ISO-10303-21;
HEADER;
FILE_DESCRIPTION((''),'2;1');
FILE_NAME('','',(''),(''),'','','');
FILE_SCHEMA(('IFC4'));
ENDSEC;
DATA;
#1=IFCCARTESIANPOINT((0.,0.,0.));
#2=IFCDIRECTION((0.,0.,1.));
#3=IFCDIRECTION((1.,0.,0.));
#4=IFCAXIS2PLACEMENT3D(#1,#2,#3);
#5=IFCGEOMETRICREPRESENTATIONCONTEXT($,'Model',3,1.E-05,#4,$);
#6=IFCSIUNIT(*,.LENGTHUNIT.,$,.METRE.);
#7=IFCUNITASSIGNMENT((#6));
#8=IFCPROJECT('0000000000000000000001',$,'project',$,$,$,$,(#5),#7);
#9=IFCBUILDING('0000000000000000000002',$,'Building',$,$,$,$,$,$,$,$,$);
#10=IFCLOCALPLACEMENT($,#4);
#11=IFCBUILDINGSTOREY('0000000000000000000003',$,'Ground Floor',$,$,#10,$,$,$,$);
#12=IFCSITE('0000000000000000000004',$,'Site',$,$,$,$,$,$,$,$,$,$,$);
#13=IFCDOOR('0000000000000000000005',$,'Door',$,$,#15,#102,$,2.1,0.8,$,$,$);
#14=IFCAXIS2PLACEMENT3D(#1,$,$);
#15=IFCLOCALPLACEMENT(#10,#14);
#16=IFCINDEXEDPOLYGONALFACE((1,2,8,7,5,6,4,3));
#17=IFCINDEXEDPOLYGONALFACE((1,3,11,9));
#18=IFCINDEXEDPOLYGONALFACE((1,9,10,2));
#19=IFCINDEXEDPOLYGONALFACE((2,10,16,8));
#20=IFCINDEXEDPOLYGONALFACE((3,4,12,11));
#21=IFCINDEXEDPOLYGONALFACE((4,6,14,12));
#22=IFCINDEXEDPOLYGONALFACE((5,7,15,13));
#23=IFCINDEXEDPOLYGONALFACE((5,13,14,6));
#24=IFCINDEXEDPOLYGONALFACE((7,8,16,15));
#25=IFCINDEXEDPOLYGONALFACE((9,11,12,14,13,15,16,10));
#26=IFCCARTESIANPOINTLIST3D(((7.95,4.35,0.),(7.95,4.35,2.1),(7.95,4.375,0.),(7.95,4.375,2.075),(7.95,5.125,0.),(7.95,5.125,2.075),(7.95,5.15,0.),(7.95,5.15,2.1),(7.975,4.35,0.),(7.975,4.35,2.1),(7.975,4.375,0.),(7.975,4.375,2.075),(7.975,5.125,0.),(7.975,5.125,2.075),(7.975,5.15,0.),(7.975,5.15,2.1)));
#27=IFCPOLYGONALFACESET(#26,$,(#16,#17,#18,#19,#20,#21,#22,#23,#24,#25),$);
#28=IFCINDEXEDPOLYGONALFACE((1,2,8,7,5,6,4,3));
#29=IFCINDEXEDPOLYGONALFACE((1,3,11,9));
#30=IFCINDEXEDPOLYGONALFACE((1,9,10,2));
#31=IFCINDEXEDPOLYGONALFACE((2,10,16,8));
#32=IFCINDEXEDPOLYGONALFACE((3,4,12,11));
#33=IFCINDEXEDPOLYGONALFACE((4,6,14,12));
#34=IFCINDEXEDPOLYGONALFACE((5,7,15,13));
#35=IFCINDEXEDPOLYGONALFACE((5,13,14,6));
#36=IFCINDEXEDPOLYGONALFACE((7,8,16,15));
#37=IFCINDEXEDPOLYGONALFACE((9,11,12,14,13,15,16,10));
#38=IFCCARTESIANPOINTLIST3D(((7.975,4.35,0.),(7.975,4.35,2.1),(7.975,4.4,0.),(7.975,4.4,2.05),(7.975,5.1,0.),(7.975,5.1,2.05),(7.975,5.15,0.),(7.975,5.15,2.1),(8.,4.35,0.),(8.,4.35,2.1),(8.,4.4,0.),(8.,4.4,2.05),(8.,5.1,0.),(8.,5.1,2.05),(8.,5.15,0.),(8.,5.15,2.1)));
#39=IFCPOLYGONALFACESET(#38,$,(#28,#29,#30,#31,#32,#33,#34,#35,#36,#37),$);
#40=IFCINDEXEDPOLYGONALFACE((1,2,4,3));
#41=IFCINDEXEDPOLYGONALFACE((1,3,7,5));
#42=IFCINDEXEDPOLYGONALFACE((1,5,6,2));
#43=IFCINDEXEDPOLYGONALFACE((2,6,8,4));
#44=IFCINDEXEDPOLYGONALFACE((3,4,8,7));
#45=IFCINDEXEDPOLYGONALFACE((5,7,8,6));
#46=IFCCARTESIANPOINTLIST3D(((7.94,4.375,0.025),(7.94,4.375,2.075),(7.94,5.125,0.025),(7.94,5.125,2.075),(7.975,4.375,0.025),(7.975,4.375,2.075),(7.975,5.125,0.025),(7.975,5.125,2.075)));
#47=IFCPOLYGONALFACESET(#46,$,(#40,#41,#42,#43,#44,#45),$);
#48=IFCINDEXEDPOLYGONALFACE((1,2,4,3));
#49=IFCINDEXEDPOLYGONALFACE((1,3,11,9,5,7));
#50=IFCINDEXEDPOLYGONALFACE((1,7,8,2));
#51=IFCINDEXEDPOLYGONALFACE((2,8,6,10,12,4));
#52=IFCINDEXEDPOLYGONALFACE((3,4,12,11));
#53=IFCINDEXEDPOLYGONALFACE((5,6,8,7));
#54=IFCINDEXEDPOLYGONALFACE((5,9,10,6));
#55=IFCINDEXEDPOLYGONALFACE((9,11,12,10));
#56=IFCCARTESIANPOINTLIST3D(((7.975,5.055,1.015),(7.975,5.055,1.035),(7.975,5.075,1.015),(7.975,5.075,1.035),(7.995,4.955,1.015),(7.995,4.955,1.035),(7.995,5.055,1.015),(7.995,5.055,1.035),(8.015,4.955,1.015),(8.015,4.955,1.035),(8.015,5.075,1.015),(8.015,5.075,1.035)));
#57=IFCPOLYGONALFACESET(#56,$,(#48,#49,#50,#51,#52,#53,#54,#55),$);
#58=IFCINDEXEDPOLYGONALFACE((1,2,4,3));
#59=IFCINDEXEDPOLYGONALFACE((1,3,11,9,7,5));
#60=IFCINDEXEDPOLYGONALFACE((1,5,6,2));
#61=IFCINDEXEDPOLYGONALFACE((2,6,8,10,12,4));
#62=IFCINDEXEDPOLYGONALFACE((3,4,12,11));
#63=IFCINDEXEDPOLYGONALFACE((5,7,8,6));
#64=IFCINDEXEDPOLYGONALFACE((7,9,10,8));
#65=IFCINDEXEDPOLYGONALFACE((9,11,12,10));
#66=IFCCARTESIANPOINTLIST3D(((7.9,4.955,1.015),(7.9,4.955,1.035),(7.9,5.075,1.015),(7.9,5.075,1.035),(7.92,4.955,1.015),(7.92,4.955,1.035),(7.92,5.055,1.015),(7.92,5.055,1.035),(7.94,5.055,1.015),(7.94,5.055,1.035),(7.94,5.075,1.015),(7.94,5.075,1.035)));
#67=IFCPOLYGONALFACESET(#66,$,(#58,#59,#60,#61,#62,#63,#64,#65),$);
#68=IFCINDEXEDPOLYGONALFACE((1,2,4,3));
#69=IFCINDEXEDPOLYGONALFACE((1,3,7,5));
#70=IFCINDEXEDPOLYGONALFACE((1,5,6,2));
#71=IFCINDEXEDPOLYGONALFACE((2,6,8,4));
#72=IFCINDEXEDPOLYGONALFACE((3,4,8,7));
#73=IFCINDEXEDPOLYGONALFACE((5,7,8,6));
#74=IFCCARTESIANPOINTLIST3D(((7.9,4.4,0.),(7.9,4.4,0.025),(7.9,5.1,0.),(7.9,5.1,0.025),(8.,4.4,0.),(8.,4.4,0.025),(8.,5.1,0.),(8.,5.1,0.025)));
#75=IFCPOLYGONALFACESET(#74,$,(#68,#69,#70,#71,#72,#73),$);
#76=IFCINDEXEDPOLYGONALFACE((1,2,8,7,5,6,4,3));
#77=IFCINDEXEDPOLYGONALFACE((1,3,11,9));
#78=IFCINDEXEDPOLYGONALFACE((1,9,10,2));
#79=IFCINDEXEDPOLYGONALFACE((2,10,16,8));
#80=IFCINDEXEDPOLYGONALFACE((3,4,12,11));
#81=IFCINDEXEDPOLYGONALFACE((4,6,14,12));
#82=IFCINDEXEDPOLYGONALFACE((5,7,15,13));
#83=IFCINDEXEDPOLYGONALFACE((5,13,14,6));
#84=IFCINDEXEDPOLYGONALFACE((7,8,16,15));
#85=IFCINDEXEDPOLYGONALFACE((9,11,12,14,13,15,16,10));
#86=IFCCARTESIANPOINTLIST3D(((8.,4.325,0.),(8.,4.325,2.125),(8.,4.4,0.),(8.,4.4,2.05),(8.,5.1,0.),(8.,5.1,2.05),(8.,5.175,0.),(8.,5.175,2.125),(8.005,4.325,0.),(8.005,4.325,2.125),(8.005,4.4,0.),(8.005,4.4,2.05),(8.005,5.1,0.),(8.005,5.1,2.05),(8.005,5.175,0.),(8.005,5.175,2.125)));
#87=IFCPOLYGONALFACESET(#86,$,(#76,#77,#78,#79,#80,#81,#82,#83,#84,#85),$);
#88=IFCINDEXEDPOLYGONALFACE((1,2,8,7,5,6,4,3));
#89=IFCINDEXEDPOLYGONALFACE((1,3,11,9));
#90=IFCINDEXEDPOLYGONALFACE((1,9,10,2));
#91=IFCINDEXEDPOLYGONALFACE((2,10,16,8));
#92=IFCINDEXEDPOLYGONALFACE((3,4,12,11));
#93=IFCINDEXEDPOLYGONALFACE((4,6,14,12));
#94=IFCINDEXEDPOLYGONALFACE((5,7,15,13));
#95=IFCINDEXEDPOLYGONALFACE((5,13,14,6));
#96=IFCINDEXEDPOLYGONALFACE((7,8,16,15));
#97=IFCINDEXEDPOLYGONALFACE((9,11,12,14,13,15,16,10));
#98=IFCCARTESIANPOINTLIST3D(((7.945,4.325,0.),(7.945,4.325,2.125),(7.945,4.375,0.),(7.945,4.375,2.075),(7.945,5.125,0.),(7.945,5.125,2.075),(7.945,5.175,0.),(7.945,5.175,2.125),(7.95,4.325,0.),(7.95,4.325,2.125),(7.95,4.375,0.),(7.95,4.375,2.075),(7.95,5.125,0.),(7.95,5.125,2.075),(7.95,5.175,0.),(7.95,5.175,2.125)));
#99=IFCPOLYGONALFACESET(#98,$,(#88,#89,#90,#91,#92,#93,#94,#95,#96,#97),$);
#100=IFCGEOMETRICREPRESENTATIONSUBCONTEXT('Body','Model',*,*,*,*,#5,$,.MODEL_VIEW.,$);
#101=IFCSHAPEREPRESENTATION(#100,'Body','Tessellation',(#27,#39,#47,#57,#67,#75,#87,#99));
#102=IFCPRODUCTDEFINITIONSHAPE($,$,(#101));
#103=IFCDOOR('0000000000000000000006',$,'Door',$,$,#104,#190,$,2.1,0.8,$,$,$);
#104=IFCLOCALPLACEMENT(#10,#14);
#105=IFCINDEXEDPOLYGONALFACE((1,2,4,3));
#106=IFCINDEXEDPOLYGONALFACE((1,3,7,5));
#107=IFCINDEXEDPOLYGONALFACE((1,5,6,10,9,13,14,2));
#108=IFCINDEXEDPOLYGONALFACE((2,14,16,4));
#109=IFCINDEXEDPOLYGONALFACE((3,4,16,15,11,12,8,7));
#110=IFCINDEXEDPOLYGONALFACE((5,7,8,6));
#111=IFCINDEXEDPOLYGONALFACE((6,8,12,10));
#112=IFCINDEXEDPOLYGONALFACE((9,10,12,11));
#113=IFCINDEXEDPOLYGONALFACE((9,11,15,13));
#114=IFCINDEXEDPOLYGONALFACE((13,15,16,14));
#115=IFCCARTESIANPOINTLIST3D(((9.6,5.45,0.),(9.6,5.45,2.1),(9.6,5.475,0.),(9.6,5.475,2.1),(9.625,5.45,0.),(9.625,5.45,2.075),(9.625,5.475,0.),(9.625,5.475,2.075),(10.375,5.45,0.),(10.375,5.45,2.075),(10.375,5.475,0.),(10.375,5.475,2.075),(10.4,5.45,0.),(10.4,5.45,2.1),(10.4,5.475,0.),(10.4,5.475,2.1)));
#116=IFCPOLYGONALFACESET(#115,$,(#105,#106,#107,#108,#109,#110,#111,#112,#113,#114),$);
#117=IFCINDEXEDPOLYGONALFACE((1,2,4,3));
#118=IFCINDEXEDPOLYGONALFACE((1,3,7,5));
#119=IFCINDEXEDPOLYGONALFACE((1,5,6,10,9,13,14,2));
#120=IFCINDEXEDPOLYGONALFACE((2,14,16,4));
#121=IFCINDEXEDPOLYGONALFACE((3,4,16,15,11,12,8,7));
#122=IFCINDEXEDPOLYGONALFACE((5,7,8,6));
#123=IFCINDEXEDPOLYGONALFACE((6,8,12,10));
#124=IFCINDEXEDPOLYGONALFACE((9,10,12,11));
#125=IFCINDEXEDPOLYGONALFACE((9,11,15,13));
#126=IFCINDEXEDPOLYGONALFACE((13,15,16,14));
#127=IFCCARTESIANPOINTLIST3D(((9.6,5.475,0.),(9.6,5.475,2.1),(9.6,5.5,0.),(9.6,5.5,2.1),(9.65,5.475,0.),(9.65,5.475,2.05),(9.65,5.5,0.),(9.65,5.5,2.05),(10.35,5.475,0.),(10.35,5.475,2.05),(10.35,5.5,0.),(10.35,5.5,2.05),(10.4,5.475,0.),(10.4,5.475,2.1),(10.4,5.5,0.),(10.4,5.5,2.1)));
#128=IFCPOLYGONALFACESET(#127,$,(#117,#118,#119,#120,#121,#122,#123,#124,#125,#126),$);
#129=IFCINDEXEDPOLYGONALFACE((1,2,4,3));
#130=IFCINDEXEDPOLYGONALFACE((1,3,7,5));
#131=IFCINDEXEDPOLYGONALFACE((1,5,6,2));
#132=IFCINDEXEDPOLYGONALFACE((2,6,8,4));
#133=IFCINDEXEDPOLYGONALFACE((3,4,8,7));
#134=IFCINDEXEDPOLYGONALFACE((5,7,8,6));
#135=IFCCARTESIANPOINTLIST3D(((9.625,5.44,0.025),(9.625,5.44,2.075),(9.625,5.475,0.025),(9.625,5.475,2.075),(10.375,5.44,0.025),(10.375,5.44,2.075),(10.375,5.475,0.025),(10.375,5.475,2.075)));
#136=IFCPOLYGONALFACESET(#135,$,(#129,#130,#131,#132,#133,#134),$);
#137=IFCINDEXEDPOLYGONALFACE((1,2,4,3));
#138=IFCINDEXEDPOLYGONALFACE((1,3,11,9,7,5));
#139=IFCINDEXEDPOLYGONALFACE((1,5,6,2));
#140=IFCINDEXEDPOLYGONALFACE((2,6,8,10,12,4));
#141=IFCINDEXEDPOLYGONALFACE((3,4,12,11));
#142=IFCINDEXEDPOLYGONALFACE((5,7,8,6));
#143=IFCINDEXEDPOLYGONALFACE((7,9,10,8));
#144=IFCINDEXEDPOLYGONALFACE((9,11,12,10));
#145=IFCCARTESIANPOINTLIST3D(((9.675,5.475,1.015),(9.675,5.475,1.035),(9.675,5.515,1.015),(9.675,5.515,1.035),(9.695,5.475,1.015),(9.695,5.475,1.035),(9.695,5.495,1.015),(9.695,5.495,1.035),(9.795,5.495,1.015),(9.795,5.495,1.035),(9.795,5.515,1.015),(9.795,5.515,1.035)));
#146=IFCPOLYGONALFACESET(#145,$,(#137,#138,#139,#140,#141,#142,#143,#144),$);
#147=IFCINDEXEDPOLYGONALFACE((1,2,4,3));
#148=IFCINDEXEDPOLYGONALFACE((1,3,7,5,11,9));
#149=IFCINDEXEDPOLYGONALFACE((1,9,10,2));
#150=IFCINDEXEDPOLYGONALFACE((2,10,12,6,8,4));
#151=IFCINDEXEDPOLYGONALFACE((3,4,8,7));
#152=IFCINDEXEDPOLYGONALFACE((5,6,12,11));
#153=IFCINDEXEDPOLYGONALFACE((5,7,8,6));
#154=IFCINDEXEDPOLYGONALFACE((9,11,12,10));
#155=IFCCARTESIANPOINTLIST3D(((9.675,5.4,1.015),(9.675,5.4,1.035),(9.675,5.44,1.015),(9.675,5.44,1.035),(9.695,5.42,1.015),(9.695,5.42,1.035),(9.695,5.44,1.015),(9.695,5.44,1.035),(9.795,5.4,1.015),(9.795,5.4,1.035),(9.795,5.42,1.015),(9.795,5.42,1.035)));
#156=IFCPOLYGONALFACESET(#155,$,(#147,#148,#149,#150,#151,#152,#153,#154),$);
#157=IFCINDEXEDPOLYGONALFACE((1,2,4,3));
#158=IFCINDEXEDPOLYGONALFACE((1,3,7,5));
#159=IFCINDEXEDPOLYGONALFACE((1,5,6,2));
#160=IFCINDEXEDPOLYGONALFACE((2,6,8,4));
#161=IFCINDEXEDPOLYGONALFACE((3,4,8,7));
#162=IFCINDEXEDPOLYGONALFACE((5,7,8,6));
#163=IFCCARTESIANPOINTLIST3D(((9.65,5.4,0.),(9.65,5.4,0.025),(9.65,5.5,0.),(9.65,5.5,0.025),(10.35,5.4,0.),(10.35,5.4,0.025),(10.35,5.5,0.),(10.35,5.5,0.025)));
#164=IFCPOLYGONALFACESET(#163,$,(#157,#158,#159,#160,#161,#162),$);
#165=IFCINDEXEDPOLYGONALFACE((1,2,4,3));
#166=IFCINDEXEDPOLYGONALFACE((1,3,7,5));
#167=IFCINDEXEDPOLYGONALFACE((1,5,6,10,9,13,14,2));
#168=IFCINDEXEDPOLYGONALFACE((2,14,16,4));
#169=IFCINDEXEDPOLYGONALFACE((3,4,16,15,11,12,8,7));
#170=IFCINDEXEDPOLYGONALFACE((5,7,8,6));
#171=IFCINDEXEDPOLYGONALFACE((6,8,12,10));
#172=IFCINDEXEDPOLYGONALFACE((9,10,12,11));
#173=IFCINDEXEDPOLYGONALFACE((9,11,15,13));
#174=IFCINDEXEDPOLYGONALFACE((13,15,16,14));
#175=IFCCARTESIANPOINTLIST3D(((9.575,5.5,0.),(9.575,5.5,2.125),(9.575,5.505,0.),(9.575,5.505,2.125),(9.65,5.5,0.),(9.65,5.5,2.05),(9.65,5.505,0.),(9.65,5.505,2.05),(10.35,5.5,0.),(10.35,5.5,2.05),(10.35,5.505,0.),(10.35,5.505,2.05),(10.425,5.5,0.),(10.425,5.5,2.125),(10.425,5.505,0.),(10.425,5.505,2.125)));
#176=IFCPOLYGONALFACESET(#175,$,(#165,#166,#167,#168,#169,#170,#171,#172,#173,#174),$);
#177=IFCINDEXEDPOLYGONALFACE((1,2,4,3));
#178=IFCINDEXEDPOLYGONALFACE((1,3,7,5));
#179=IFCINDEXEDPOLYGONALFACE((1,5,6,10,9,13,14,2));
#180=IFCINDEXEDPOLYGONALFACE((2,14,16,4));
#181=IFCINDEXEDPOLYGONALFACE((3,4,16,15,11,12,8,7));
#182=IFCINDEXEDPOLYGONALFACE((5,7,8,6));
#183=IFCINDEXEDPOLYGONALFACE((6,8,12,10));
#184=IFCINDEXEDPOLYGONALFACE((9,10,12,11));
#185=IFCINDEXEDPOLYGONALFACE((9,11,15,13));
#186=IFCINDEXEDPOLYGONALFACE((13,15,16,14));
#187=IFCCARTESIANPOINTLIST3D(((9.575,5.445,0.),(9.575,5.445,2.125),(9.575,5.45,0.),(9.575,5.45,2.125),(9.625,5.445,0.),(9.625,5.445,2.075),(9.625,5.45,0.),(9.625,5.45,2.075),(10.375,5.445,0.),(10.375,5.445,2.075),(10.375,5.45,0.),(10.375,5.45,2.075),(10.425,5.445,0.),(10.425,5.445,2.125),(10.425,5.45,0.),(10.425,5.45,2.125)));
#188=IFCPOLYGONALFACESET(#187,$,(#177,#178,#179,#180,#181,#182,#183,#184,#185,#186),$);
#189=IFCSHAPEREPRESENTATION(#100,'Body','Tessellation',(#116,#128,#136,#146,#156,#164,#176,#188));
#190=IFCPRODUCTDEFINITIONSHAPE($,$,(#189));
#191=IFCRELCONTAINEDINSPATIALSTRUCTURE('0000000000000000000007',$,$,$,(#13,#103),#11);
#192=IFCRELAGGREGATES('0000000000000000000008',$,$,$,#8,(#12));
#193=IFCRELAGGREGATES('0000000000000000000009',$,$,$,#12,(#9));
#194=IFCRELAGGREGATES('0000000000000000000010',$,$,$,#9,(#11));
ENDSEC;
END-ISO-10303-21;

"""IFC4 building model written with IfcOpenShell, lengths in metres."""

from ifc_helpers import new_model, si_unit, frame, origin_with_axes, place, context, subcontext, project, spatial, line, indexed_curve, outline, extrude, element, save


model = new_model("IFC4")

# Units and contexts
model_context = context("Model", 3, precision=1e-05, world=origin_with_axes())
body_context = subcontext(model_context, "Body", "Model", "MODEL_VIEW")
ifc_project = project(units=[si_unit("LENGTHUNIT", "METRE")], contexts=[model_context])

# Site, building, storey
site = spatial("IfcSite", under=ifc_project, Name="Site")
building = spatial("IfcBuilding", under=site, Name="Building")
storey_placement = place(None, origin_with_axes())
storey = spatial("IfcBuildingStorey", under=building, at=storey_placement, Name="Ground Floor")

# Doors
door_1_placement = place(storey_placement, frame((8.0, 4.35, 0.0), z_axis=(0.0, 0.0, 1.0), x_axis=(0.0, 1.0, 0.0)))
element("IfcDoor", 1, at=door_1_placement, inside=storey, Name="Door", OverallHeight=2.1, OverallWidth=0.8, context=body_context, shape_type="SweptSolid", body=[
    extrude(outline(indexed_curve([(0.0, 0.0), (0.0, 2.1), (0.8, 2.1), (0.8, 0.0), (0.775, 0.0), (0.775, 2.075), (0.025, 2.075), (0.025, 0.0)], segments=[line(1, 2, 3, 4, 5, 6, 7, 8, 1)])), frame((0.0, 0.025, 0.0), z_axis=(0.0, -1.0, 0.0), x_axis=(1.0, 0.0, 0.0)), (0.0, 0.0, -1.0), 0.025),
    extrude(outline(indexed_curve([(0.0, 0.0), (0.0, 2.1), (0.8, 2.1), (0.8, 0.0), (0.75, 0.0), (0.75, 2.05), (0.05, 2.05), (0.05, 0.0)], segments=[line(1, 2, 3, 4, 5, 6, 7, 8, 1)])), frame((0.0, 0.0, 0.0), z_axis=(0.0, -1.0, 0.0), x_axis=(1.0, 0.0, 0.0)), (0.0, 0.0, -1.0), 0.025),
    extrude(outline(indexed_curve([(0.0, 0.0), (0.75, 0.0), (0.75, 0.035), (0.0, 0.035)], segments=[line(1, 2, 3, 4, 1)])), frame((0.025, 0.025, 0.025), z_axis=(0.0, 0.0, 1.0), x_axis=(1.0, 0.0, 0.0)), (0.0, 0.0, 1.0), 2.05),
    extrude(outline(indexed_curve([(0.0, 0.0), (0.0, -0.04), (-0.12, -0.04), (-0.12, -0.02), (-0.02, -0.02), (-0.02, 0.0)], segments=[line(1, 2, 3, 4, 5, 6, 1)])), frame((0.725, 0.025, 1.015), z_axis=(0.0, 0.0, 1.0), x_axis=(1.0, 0.0, 0.0)), (0.0, 0.0, 1.0), 0.02),
    extrude(outline(indexed_curve([(0.0, 0.0), (0.0, 0.04), (-0.12, 0.04), (-0.12, 0.02), (-0.02, 0.02), (-0.02, 0.0)], segments=[line(1, 2, 3, 4, 5, 6, 1)])), frame((0.725, 0.06, 1.015), z_axis=(0.0, 0.0, 1.0), x_axis=(1.0, 0.0, 0.0)), (0.0, 0.0, 1.0), 0.02),
    extrude(outline(indexed_curve([(0.0, 0.0), (0.7, 0.0), (0.7, 0.1), (0.0, 0.1)], segments=[line(1, 2, 3, 4, 1)])), frame((0.05, 0.0, 0.0), z_axis=(0.0, 0.0, 1.0), x_axis=(1.0, 0.0, 0.0)), (0.0, 0.0, 1.0), 0.025),
    extrude(outline(indexed_curve([(0.0, 0.0), (0.0, 2.125), (0.85, 2.125), (0.85, 0.0), (0.775, 0.0), (0.775, 2.05), (0.075, 2.05), (0.075, 0.0)], segments=[line(1, 2, 3, 4, 5, 6, 7, 8, 1)])), frame((-0.025, -0.005, 0.0), z_axis=(0.0, -1.0, 0.0), x_axis=(1.0, 0.0, 0.0)), (0.0, 0.0, -1.0), 0.005),
    extrude(outline(indexed_curve([(0.0, 0.0), (0.0, 2.125), (0.85, 2.125), (0.85, 0.0), (0.8, 0.0), (0.8, 2.075), (0.05, 2.075), (0.05, 0.0)], segments=[line(1, 2, 3, 4, 5, 6, 7, 8, 1)])), frame((-0.025, 0.05, 0.0), z_axis=(0.0, -1.0, 0.0), x_axis=(1.0, 0.0, 0.0)), (0.0, 0.0, -1.0), 0.005),
])
door_2_placement = place(storey_placement, frame((10.4, 5.5, 0.0), z_axis=(0.0, 0.0, 1.0), x_axis=(-1.0, 0.0, 0.0)))
element("IfcDoor", 2, at=door_2_placement, inside=storey, Name="Door", OverallHeight=2.1, OverallWidth=0.8, context=body_context, shape_type="SweptSolid", body=[
    extrude(outline(indexed_curve([(0.0, 0.0), (0.0, 2.1), (0.8, 2.1), (0.8, 0.0), (0.775, 0.0), (0.775, 2.075), (0.025, 2.075), (0.025, 0.0)], segments=[line(1, 2, 3, 4, 5, 6, 7, 8, 1)])), frame((0.0, 0.025, 0.0), z_axis=(0.0, -1.0, 0.0), x_axis=(1.0, 0.0, 0.0)), (0.0, 0.0, -1.0), 0.025),
    extrude(outline(indexed_curve([(0.0, 0.0), (0.0, 2.1), (0.8, 2.1), (0.8, 0.0), (0.75, 0.0), (0.75, 2.05), (0.05, 2.05), (0.05, 0.0)], segments=[line(1, 2, 3, 4, 5, 6, 7, 8, 1)])), frame((0.0, 0.0, 0.0), z_axis=(0.0, -1.0, 0.0), x_axis=(1.0, 0.0, 0.0)), (0.0, 0.0, -1.0), 0.025),
    extrude(outline(indexed_curve([(0.0, 0.0), (0.75, 0.0), (0.75, 0.035), (0.0, 0.035)], segments=[line(1, 2, 3, 4, 1)])), frame((0.025, 0.025, 0.025), z_axis=(0.0, 0.0, 1.0), x_axis=(1.0, 0.0, 0.0)), (0.0, 0.0, 1.0), 2.05),
    extrude(outline(indexed_curve([(0.0, 0.0), (0.0, -0.04), (-0.12, -0.04), (-0.12, -0.02), (-0.02, -0.02), (-0.02, 0.0)], segments=[line(1, 2, 3, 4, 5, 6, 1)])), frame((0.725, 0.025, 1.015), z_axis=(0.0, 0.0, 1.0), x_axis=(1.0, 0.0, 0.0)), (0.0, 0.0, 1.0), 0.02),
    extrude(outline(indexed_curve([(0.0, 0.0), (0.0, 0.04), (-0.12, 0.04), (-0.12, 0.02), (-0.02, 0.02), (-0.02, 0.0)], segments=[line(1, 2, 3, 4, 5, 6, 1)])), frame((0.725, 0.06, 1.015), z_axis=(0.0, 0.0, 1.0), x_axis=(1.0, 0.0, 0.0)), (0.0, 0.0, 1.0), 0.02),
    extrude(outline(indexed_curve([(0.0, 0.0), (0.7, 0.0), (0.7, 0.1), (0.0, 0.1)], segments=[line(1, 2, 3, 4, 1)])), frame((0.05, 0.0, 0.0), z_axis=(0.0, 0.0, 1.0), x_axis=(1.0, 0.0, 0.0)), (0.0, 0.0, 1.0), 0.025),
    extrude(outline(indexed_curve([(0.0, 0.0), (0.0, 2.125), (0.85, 2.125), (0.85, 0.0), (0.775, 0.0), (0.775, 2.05), (0.075, 2.05), (0.075, 0.0)], segments=[line(1, 2, 3, 4, 5, 6, 7, 8, 1)])), frame((-0.025, -0.005, 0.0), z_axis=(0.0, -1.0, 0.0), x_axis=(1.0, 0.0, 0.0)), (0.0, 0.0, -1.0), 0.005),
    extrude(outline(indexed_curve([(0.0, 0.0), (0.0, 2.125), (0.85, 2.125), (0.85, 0.0), (0.8, 0.0), (0.8, 2.075), (0.05, 2.075), (0.05, 0.0)], segments=[line(1, 2, 3, 4, 5, 6, 7, 8, 1)])), frame((-0.025, 0.05, 0.0), z_axis=(0.0, -1.0, 0.0), x_axis=(1.0, 0.0, 0.0)), (0.0, 0.0, -1.0), 0.005),
])

save(model, "model.ifc")
